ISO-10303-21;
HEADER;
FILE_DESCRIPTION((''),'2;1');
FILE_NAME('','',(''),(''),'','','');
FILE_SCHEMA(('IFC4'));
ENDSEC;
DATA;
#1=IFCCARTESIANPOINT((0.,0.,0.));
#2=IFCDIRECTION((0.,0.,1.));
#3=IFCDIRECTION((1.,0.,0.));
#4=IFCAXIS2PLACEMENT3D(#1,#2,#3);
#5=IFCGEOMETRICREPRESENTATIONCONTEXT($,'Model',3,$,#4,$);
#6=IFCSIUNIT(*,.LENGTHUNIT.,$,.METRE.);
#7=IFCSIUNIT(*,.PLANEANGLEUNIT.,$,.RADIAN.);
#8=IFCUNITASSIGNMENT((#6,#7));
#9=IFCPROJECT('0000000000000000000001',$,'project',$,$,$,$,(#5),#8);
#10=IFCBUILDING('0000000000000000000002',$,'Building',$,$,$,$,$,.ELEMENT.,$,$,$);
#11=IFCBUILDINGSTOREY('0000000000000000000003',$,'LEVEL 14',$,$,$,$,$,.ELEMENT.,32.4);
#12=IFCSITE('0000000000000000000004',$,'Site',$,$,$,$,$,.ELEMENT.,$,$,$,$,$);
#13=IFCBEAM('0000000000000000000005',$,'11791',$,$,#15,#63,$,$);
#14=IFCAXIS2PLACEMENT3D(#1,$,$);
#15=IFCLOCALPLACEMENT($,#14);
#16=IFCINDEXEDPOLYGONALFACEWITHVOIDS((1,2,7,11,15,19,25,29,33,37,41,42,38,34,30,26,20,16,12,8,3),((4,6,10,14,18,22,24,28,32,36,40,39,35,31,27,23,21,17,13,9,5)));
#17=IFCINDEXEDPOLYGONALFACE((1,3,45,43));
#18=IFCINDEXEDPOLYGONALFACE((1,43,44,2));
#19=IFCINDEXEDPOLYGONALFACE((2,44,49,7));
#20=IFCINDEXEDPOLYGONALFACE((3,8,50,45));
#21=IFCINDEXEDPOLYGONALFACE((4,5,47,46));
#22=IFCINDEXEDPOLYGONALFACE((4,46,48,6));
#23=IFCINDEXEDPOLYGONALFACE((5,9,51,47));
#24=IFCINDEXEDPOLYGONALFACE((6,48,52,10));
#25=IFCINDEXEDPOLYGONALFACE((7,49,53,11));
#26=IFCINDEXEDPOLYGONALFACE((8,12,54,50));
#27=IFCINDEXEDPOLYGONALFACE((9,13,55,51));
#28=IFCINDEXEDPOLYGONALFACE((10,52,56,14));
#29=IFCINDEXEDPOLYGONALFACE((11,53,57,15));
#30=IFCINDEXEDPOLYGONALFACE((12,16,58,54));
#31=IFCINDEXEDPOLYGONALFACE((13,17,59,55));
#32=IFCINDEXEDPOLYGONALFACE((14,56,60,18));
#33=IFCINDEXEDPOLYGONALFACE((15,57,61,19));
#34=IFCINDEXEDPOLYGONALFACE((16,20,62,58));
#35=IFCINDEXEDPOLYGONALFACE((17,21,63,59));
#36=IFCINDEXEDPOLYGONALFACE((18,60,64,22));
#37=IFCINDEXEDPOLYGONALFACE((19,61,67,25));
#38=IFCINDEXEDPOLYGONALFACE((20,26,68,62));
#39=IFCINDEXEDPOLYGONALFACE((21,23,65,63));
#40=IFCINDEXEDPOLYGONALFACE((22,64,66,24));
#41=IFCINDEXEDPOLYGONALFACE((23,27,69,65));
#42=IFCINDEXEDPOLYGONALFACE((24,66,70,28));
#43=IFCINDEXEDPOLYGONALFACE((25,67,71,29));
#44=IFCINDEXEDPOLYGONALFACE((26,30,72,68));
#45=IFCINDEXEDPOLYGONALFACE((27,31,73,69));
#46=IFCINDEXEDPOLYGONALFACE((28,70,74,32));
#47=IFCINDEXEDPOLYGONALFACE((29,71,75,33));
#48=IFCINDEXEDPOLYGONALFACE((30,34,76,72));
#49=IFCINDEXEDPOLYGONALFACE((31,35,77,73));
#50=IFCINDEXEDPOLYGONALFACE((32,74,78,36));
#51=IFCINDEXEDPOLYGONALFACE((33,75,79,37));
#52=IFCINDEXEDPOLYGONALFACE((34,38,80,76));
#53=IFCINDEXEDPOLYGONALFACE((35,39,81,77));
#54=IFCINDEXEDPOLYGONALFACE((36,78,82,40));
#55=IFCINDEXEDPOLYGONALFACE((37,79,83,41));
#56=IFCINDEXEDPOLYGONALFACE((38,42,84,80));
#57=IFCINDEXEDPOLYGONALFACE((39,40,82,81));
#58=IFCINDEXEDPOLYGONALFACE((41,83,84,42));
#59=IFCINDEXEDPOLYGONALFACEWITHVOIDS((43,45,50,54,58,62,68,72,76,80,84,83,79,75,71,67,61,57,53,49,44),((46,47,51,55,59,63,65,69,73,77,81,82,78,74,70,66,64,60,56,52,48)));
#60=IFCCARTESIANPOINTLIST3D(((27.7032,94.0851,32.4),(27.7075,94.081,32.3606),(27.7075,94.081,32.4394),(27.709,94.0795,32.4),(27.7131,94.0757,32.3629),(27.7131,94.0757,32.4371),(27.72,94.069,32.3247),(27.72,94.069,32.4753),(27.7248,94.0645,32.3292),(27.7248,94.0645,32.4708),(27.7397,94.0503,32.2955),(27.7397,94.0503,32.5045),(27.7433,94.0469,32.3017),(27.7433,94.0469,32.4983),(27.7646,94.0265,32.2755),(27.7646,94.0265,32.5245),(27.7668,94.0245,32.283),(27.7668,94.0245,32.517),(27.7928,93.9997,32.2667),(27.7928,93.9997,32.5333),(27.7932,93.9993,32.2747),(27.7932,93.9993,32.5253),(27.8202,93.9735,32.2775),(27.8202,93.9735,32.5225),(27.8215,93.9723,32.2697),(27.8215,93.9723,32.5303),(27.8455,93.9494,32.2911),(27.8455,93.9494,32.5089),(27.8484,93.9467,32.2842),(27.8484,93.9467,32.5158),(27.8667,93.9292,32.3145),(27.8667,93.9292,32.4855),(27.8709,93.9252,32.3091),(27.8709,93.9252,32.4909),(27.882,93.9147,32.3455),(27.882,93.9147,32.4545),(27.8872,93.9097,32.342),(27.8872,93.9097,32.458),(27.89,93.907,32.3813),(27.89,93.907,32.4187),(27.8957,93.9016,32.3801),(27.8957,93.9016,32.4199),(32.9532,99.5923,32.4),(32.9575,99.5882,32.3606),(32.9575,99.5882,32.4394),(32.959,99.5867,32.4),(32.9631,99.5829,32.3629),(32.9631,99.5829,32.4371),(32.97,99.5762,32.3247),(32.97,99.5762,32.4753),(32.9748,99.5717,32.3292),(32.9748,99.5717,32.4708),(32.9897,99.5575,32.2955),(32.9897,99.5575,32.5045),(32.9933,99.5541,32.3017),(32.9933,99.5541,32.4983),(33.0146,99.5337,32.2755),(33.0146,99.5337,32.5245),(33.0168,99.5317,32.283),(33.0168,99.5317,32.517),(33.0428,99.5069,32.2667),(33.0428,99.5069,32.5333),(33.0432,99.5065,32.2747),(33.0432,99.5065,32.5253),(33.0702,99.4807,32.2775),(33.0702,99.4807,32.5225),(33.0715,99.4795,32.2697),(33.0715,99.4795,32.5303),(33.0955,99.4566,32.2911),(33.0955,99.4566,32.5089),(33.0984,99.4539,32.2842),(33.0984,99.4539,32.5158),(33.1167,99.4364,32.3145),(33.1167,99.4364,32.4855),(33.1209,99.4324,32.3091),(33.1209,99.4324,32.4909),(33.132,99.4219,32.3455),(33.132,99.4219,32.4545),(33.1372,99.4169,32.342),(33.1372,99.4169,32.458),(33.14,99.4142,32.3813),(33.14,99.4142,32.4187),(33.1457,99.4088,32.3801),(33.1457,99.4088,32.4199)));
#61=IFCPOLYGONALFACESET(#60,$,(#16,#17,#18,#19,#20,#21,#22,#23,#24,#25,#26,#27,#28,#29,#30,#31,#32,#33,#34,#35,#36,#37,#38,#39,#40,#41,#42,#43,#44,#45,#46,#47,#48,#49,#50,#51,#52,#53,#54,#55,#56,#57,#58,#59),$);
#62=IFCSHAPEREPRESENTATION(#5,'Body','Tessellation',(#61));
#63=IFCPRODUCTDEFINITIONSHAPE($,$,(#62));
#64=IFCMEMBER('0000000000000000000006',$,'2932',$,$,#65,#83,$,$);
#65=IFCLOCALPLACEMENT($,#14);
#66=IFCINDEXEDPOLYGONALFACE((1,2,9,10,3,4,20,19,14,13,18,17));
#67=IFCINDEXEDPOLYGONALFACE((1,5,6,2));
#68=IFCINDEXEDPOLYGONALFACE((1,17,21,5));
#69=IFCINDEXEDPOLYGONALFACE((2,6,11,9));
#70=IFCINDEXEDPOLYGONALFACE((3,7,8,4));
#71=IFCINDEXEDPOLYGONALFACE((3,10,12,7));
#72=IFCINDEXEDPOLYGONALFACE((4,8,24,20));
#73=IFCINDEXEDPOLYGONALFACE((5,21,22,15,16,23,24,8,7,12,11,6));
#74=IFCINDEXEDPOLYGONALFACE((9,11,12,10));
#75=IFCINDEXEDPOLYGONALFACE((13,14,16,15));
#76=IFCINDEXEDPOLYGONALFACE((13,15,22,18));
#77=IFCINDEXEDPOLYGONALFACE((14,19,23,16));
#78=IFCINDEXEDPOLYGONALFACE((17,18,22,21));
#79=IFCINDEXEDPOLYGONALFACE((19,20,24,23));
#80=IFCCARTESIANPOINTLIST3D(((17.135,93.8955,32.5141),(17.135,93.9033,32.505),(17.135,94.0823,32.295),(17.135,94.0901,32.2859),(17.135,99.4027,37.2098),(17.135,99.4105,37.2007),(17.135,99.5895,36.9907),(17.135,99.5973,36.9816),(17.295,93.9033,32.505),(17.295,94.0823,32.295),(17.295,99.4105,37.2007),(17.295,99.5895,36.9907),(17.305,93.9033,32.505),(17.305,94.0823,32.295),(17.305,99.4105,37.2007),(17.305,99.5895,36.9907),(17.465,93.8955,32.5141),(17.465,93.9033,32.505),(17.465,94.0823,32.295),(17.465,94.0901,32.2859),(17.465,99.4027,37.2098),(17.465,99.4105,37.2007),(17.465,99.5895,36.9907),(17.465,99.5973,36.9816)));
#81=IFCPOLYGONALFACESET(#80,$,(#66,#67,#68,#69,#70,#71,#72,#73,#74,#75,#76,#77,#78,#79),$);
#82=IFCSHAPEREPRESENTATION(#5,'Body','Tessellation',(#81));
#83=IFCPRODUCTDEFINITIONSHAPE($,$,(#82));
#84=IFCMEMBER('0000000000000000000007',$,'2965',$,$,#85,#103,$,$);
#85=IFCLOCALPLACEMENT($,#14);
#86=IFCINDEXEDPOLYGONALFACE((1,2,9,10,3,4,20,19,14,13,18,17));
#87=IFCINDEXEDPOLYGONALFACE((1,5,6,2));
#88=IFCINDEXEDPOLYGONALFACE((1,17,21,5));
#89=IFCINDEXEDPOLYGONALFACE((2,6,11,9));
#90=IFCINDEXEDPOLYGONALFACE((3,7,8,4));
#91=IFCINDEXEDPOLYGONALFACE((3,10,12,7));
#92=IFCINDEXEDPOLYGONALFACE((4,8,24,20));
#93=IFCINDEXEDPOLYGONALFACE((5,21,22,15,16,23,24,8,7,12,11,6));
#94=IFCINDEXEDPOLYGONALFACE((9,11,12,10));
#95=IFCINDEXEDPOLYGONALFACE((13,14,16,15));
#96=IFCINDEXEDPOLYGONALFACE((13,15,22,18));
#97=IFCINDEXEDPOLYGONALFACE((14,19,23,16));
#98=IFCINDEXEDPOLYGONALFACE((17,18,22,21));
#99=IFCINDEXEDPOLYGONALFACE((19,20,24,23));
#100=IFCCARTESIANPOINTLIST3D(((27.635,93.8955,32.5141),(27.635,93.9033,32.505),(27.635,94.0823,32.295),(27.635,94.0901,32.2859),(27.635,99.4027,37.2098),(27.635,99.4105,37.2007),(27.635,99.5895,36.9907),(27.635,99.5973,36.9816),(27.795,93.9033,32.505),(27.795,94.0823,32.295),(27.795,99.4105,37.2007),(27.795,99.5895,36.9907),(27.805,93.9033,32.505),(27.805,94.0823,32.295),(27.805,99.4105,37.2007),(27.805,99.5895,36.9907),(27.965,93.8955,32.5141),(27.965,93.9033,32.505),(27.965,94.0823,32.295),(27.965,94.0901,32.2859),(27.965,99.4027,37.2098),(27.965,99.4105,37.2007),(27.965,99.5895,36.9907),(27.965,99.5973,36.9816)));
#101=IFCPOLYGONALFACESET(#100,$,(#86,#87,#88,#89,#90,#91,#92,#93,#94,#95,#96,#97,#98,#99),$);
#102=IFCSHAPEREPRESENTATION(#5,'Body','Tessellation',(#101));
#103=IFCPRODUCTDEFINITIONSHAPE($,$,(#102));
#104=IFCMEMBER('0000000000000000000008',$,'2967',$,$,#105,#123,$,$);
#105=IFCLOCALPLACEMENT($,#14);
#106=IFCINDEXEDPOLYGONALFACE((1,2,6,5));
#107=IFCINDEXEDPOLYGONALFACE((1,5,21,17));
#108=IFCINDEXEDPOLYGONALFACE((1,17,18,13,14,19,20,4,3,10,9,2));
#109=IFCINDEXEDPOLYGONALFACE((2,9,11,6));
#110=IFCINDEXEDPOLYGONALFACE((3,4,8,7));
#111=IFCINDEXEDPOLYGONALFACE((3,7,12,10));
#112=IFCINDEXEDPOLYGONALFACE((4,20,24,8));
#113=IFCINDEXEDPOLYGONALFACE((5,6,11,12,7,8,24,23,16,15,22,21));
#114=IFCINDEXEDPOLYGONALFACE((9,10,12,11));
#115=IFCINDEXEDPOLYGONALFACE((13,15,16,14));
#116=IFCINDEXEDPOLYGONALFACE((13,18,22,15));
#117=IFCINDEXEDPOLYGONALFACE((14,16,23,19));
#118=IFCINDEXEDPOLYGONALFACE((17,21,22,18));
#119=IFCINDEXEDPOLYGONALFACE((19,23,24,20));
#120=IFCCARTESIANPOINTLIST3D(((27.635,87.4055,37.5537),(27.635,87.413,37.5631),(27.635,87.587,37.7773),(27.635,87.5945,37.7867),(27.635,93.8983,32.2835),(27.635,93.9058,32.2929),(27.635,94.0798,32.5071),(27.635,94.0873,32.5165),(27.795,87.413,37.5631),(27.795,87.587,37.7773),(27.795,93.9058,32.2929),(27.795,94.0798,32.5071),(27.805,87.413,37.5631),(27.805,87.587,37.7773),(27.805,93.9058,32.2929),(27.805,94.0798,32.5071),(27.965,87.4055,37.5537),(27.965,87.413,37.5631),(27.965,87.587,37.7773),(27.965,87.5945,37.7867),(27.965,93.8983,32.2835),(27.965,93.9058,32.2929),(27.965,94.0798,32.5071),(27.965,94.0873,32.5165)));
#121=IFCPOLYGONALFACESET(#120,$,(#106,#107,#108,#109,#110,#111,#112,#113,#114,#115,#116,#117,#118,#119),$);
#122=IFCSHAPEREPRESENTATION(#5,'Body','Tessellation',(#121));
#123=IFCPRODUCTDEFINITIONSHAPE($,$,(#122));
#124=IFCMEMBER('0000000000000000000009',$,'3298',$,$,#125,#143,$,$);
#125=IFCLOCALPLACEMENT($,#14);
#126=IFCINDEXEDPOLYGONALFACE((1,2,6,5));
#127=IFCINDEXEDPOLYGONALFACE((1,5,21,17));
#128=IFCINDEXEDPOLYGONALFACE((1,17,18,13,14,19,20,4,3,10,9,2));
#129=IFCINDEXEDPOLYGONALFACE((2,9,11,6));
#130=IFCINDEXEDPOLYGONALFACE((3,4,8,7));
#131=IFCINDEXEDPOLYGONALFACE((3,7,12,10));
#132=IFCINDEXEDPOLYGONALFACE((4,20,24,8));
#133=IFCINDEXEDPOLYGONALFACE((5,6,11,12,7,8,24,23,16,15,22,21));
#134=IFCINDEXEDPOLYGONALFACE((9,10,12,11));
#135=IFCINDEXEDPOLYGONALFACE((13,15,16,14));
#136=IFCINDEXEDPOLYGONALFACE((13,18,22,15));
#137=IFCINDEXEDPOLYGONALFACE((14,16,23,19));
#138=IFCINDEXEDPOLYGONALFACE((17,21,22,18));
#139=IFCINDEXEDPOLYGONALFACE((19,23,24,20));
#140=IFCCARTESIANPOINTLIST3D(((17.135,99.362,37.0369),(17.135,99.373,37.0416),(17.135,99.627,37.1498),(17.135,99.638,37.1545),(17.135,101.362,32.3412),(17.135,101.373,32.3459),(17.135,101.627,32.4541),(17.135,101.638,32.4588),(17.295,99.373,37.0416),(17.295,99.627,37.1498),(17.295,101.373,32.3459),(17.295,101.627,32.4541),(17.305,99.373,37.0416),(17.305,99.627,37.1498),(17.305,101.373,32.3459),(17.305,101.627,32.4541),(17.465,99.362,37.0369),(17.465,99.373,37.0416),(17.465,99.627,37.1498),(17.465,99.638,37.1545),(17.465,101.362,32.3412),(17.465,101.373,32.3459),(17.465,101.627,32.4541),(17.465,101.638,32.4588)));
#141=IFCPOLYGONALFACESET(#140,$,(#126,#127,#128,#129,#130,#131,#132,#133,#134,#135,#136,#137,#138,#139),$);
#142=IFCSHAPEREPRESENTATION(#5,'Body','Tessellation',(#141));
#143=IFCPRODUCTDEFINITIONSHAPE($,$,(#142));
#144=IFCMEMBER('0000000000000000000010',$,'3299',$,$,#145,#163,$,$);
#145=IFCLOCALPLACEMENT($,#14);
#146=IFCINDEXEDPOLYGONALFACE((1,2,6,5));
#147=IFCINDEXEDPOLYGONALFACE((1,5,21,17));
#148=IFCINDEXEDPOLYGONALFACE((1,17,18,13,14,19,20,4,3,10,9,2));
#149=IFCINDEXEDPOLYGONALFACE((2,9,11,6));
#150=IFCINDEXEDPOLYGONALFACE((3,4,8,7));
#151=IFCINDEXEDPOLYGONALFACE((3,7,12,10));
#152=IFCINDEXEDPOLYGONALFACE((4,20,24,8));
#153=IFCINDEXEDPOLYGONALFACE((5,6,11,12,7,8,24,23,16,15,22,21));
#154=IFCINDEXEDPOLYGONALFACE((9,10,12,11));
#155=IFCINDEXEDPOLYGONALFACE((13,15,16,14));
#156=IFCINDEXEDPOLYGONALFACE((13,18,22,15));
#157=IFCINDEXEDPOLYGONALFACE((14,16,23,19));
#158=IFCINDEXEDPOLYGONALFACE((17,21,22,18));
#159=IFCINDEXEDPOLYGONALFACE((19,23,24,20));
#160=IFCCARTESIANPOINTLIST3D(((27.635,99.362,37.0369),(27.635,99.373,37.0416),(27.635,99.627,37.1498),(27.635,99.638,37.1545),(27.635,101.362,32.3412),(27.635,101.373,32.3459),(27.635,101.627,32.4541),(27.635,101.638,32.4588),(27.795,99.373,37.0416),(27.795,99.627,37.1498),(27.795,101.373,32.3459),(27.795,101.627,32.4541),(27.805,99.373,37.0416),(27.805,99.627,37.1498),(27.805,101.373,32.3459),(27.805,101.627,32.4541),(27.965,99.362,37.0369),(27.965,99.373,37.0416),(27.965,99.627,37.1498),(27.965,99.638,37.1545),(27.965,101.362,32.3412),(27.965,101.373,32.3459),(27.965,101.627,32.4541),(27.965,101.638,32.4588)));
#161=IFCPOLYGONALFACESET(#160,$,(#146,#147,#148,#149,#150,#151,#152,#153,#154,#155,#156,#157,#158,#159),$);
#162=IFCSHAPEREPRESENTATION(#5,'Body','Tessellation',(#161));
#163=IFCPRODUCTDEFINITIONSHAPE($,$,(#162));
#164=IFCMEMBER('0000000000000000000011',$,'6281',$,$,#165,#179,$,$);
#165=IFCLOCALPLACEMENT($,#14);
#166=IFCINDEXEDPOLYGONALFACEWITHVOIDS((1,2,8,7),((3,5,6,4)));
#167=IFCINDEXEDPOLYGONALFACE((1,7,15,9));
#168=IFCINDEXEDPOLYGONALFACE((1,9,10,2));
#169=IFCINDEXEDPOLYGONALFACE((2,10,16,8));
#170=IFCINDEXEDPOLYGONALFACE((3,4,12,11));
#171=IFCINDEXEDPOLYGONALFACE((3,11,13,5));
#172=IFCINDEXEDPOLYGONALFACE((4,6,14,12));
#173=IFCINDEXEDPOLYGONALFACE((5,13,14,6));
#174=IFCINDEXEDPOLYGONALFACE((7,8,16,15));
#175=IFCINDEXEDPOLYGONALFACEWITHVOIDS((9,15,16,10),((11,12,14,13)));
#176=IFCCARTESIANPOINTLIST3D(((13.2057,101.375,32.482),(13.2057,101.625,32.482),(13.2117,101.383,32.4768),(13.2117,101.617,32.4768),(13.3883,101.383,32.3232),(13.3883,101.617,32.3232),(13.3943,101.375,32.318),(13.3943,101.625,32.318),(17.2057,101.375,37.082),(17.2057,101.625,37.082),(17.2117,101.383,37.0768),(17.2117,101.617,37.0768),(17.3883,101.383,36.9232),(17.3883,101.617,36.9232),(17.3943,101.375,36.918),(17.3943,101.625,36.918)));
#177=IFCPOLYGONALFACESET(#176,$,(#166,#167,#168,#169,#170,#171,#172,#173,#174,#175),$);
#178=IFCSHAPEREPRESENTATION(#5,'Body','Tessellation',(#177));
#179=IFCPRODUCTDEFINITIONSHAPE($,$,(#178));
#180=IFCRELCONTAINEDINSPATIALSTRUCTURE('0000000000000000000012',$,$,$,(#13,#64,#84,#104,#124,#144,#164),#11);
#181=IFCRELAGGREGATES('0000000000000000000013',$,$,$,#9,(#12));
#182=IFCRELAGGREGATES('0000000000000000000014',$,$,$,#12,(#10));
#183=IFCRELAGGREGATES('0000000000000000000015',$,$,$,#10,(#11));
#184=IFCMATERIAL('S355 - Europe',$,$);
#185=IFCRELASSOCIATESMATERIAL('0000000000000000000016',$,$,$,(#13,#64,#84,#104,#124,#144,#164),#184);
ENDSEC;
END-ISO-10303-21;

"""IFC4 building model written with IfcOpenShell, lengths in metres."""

from ifc_helpers import new_model, si_unit, frame, origin_with_axes, origin_2d_with_axis, place, context, project, spatial, hollow_rectangle, hollow_circle, i_section, extrude, material, material_profile, profile_set, profile_usage, element, save


model = new_model("IFC4")

# Units and contexts
model_context = context("Model", 3, world=origin_with_axes())
ifc_project = project(units=[si_unit("LENGTHUNIT", "METRE"), si_unit("PLANEANGLEUNIT", "RADIAN")], contexts=[model_context])

# Site, building, storey
site = spatial("IfcSite", under=ifc_project, Name="Site", CompositionType="ELEMENT")
building = spatial("IfcBuilding", under=site, Name="Building", CompositionType="ELEMENT")
storey = spatial("IfcBuildingStorey", under=building, Name="LEVEL 14", CompositionType="ELEMENT", Elevation=32.4)

# Shared definitions
ifc_material = material(Name="S355 - Europe")

# Beam
ifc_material_profile_1 = material_profile(ifc_material, hollow_circle(Radius=0.1337, WallThickness=0.008, at=origin_2d_with_axis()))
ifc_profile_set_1 = profile_set([ifc_material_profile_1])
ifc_profile_usage_1 = profile_usage(ifc_profile_set_1, cardinal=10)
beam_1_placement = place(None, frame((27.8, 93.9928, 32.4), z_axis=(0.690003, 0.723807, 0.0), x_axis=(-0.723807, 0.690003, 0.0)))
element("IfcBeam", 1, at=beam_1_placement, inside=storey, material=ifc_profile_usage_1, Name="11791", context=model_context, shape_type="SweptSolid", body=[
    extrude(hollow_circle(Radius=0.1337, WallThickness=0.008, at=origin_2d_with_axis()), origin_with_axes(), (0.0, 0.0, 1.0), 7.6087),
])

# Members
ifc_material_profile_2 = material_profile(ifc_material, i_section(OverallWidth=0.33, OverallDepth=0.3, WebThickness=0.01, FlangeThickness=0.012, at=origin_2d_with_axis()))
ifc_profile_set_2 = profile_set([ifc_material_profile_2])
ifc_profile_usage_2 = profile_usage(ifc_profile_set_2, cardinal=10)
member_1_placement = place(None, frame((17.3, 99.5, 37.0957), z_axis=(0.0, -0.760944, -0.648817), x_axis=(1.0, 0.0, 0.0)))
element("IfcMember", 2, at=member_1_placement, inside=storey, material=ifc_profile_usage_2, Name="2932", context=model_context, shape_type="SweptSolid", body=[
    extrude(i_section(OverallWidth=0.33, OverallDepth=0.3, WebThickness=0.01, FlangeThickness=0.012, at=origin_2d_with_axis()), origin_with_axes(), (0.0, 0.0, 1.0), 7.2373),
])
ifc_material_profile_3 = material_profile(ifc_material, i_section(OverallWidth=0.33, OverallDepth=0.3, WebThickness=0.01, FlangeThickness=0.012, at=origin_2d_with_axis()))
ifc_profile_set_3 = profile_set([ifc_material_profile_3])
ifc_profile_usage_3 = profile_usage(ifc_profile_set_3, cardinal=10)
member_2_placement = place(None, frame((27.8, 93.9928, 32.4), z_axis=(0.0, 0.760944, 0.648817), x_axis=(-1.0, 0.0, 0.0)))
element("IfcMember", 3, at=member_2_placement, inside=storey, material=ifc_profile_usage_3, Name="2965", context=model_context, shape_type="SweptSolid", body=[
    extrude(i_section(OverallWidth=0.33, OverallDepth=0.3, WebThickness=0.01, FlangeThickness=0.012, at=origin_2d_with_axis()), origin_with_axes(), (0.0, 0.0, 1.0), 7.2373),
])
ifc_material_profile_4 = material_profile(ifc_material, i_section(OverallWidth=0.33, OverallDepth=0.3, WebThickness=0.01, FlangeThickness=0.012, at=origin_2d_with_axis()))
ifc_profile_set_4 = profile_set([ifc_material_profile_4])
ifc_profile_usage_4 = profile_usage(ifc_profile_set_4, cardinal=10)
member_3_placement = place(None, frame((27.8, 93.9928, 32.4), z_axis=(0.0, -0.776418, 0.630218), x_axis=(1.0, 0.0, 0.0)))
element("IfcMember", 4, at=member_3_placement, inside=storey, material=ifc_profile_usage_4, Name="2967", context=model_context, shape_type="SweptSolid", body=[
    extrude(i_section(OverallWidth=0.33, OverallDepth=0.3, WebThickness=0.01, FlangeThickness=0.012, at=origin_2d_with_axis()), origin_with_axes(), (0.0, 0.0, 1.0), 8.3625),
])
ifc_material_profile_5 = material_profile(ifc_material, i_section(OverallWidth=0.33, OverallDepth=0.3, WebThickness=0.01, FlangeThickness=0.012, at=origin_2d_with_axis()))
ifc_profile_set_5 = profile_set([ifc_material_profile_5])
ifc_profile_usage_5 = profile_usage(ifc_profile_set_5, cardinal=10)
member_4_placement = place(None, frame((17.3, 99.5, 37.0957), z_axis=(0.0, 0.391859, -0.920025), x_axis=(-1.0, 0.0, 0.0)))
element("IfcMember", 5, at=member_4_placement, inside=storey, material=ifc_profile_usage_5, Name="3298", context=model_context, shape_type="SweptSolid", body=[
    extrude(i_section(OverallWidth=0.33, OverallDepth=0.3, WebThickness=0.01, FlangeThickness=0.012, at=origin_2d_with_axis()), origin_with_axes(), (0.0, 0.0, 1.0), 5.1039),
])
ifc_material_profile_6 = material_profile(ifc_material, i_section(OverallWidth=0.33, OverallDepth=0.3, WebThickness=0.01, FlangeThickness=0.012, at=origin_2d_with_axis()))
ifc_profile_set_6 = profile_set([ifc_material_profile_6])
ifc_profile_usage_6 = profile_usage(ifc_profile_set_6, cardinal=10)
member_5_placement = place(None, frame((27.8, 99.5, 37.0957), z_axis=(0.0, 0.391859, -0.920025), x_axis=(-1.0, 0.0, 0.0)))
element("IfcMember", 6, at=member_5_placement, inside=storey, material=ifc_profile_usage_6, Name="3299", context=model_context, shape_type="SweptSolid", body=[
    extrude(i_section(OverallWidth=0.33, OverallDepth=0.3, WebThickness=0.01, FlangeThickness=0.012, at=origin_2d_with_axis()), origin_with_axes(), (0.0, 0.0, 1.0), 5.1039),
])
ifc_material_profile_7 = material_profile(ifc_material, hollow_rectangle(XDim=0.25, YDim=0.25, WallThickness=0.008, at=origin_2d_with_axis()))
ifc_profile_set_7 = profile_set([ifc_material_profile_7])
ifc_profile_usage_7 = profile_usage(ifc_profile_set_7, cardinal=10)
member_6_placement = place(None, frame((17.3, 101.5, 37.0), z_axis=(-0.656179, 0.0, -0.754606), x_axis=(0.0, -1.0, 0.0)))
element("IfcMember", 7, at=member_6_placement, inside=storey, material=ifc_profile_usage_7, Name="6281", context=model_context, shape_type="SweptSolid", body=[
    extrude(hollow_rectangle(XDim=0.25, YDim=0.25, WallThickness=0.008, at=origin_2d_with_axis()), origin_with_axes(), (0.0, 0.0, 1.0), 6.0959),
])

save(model, "model.ifc")
